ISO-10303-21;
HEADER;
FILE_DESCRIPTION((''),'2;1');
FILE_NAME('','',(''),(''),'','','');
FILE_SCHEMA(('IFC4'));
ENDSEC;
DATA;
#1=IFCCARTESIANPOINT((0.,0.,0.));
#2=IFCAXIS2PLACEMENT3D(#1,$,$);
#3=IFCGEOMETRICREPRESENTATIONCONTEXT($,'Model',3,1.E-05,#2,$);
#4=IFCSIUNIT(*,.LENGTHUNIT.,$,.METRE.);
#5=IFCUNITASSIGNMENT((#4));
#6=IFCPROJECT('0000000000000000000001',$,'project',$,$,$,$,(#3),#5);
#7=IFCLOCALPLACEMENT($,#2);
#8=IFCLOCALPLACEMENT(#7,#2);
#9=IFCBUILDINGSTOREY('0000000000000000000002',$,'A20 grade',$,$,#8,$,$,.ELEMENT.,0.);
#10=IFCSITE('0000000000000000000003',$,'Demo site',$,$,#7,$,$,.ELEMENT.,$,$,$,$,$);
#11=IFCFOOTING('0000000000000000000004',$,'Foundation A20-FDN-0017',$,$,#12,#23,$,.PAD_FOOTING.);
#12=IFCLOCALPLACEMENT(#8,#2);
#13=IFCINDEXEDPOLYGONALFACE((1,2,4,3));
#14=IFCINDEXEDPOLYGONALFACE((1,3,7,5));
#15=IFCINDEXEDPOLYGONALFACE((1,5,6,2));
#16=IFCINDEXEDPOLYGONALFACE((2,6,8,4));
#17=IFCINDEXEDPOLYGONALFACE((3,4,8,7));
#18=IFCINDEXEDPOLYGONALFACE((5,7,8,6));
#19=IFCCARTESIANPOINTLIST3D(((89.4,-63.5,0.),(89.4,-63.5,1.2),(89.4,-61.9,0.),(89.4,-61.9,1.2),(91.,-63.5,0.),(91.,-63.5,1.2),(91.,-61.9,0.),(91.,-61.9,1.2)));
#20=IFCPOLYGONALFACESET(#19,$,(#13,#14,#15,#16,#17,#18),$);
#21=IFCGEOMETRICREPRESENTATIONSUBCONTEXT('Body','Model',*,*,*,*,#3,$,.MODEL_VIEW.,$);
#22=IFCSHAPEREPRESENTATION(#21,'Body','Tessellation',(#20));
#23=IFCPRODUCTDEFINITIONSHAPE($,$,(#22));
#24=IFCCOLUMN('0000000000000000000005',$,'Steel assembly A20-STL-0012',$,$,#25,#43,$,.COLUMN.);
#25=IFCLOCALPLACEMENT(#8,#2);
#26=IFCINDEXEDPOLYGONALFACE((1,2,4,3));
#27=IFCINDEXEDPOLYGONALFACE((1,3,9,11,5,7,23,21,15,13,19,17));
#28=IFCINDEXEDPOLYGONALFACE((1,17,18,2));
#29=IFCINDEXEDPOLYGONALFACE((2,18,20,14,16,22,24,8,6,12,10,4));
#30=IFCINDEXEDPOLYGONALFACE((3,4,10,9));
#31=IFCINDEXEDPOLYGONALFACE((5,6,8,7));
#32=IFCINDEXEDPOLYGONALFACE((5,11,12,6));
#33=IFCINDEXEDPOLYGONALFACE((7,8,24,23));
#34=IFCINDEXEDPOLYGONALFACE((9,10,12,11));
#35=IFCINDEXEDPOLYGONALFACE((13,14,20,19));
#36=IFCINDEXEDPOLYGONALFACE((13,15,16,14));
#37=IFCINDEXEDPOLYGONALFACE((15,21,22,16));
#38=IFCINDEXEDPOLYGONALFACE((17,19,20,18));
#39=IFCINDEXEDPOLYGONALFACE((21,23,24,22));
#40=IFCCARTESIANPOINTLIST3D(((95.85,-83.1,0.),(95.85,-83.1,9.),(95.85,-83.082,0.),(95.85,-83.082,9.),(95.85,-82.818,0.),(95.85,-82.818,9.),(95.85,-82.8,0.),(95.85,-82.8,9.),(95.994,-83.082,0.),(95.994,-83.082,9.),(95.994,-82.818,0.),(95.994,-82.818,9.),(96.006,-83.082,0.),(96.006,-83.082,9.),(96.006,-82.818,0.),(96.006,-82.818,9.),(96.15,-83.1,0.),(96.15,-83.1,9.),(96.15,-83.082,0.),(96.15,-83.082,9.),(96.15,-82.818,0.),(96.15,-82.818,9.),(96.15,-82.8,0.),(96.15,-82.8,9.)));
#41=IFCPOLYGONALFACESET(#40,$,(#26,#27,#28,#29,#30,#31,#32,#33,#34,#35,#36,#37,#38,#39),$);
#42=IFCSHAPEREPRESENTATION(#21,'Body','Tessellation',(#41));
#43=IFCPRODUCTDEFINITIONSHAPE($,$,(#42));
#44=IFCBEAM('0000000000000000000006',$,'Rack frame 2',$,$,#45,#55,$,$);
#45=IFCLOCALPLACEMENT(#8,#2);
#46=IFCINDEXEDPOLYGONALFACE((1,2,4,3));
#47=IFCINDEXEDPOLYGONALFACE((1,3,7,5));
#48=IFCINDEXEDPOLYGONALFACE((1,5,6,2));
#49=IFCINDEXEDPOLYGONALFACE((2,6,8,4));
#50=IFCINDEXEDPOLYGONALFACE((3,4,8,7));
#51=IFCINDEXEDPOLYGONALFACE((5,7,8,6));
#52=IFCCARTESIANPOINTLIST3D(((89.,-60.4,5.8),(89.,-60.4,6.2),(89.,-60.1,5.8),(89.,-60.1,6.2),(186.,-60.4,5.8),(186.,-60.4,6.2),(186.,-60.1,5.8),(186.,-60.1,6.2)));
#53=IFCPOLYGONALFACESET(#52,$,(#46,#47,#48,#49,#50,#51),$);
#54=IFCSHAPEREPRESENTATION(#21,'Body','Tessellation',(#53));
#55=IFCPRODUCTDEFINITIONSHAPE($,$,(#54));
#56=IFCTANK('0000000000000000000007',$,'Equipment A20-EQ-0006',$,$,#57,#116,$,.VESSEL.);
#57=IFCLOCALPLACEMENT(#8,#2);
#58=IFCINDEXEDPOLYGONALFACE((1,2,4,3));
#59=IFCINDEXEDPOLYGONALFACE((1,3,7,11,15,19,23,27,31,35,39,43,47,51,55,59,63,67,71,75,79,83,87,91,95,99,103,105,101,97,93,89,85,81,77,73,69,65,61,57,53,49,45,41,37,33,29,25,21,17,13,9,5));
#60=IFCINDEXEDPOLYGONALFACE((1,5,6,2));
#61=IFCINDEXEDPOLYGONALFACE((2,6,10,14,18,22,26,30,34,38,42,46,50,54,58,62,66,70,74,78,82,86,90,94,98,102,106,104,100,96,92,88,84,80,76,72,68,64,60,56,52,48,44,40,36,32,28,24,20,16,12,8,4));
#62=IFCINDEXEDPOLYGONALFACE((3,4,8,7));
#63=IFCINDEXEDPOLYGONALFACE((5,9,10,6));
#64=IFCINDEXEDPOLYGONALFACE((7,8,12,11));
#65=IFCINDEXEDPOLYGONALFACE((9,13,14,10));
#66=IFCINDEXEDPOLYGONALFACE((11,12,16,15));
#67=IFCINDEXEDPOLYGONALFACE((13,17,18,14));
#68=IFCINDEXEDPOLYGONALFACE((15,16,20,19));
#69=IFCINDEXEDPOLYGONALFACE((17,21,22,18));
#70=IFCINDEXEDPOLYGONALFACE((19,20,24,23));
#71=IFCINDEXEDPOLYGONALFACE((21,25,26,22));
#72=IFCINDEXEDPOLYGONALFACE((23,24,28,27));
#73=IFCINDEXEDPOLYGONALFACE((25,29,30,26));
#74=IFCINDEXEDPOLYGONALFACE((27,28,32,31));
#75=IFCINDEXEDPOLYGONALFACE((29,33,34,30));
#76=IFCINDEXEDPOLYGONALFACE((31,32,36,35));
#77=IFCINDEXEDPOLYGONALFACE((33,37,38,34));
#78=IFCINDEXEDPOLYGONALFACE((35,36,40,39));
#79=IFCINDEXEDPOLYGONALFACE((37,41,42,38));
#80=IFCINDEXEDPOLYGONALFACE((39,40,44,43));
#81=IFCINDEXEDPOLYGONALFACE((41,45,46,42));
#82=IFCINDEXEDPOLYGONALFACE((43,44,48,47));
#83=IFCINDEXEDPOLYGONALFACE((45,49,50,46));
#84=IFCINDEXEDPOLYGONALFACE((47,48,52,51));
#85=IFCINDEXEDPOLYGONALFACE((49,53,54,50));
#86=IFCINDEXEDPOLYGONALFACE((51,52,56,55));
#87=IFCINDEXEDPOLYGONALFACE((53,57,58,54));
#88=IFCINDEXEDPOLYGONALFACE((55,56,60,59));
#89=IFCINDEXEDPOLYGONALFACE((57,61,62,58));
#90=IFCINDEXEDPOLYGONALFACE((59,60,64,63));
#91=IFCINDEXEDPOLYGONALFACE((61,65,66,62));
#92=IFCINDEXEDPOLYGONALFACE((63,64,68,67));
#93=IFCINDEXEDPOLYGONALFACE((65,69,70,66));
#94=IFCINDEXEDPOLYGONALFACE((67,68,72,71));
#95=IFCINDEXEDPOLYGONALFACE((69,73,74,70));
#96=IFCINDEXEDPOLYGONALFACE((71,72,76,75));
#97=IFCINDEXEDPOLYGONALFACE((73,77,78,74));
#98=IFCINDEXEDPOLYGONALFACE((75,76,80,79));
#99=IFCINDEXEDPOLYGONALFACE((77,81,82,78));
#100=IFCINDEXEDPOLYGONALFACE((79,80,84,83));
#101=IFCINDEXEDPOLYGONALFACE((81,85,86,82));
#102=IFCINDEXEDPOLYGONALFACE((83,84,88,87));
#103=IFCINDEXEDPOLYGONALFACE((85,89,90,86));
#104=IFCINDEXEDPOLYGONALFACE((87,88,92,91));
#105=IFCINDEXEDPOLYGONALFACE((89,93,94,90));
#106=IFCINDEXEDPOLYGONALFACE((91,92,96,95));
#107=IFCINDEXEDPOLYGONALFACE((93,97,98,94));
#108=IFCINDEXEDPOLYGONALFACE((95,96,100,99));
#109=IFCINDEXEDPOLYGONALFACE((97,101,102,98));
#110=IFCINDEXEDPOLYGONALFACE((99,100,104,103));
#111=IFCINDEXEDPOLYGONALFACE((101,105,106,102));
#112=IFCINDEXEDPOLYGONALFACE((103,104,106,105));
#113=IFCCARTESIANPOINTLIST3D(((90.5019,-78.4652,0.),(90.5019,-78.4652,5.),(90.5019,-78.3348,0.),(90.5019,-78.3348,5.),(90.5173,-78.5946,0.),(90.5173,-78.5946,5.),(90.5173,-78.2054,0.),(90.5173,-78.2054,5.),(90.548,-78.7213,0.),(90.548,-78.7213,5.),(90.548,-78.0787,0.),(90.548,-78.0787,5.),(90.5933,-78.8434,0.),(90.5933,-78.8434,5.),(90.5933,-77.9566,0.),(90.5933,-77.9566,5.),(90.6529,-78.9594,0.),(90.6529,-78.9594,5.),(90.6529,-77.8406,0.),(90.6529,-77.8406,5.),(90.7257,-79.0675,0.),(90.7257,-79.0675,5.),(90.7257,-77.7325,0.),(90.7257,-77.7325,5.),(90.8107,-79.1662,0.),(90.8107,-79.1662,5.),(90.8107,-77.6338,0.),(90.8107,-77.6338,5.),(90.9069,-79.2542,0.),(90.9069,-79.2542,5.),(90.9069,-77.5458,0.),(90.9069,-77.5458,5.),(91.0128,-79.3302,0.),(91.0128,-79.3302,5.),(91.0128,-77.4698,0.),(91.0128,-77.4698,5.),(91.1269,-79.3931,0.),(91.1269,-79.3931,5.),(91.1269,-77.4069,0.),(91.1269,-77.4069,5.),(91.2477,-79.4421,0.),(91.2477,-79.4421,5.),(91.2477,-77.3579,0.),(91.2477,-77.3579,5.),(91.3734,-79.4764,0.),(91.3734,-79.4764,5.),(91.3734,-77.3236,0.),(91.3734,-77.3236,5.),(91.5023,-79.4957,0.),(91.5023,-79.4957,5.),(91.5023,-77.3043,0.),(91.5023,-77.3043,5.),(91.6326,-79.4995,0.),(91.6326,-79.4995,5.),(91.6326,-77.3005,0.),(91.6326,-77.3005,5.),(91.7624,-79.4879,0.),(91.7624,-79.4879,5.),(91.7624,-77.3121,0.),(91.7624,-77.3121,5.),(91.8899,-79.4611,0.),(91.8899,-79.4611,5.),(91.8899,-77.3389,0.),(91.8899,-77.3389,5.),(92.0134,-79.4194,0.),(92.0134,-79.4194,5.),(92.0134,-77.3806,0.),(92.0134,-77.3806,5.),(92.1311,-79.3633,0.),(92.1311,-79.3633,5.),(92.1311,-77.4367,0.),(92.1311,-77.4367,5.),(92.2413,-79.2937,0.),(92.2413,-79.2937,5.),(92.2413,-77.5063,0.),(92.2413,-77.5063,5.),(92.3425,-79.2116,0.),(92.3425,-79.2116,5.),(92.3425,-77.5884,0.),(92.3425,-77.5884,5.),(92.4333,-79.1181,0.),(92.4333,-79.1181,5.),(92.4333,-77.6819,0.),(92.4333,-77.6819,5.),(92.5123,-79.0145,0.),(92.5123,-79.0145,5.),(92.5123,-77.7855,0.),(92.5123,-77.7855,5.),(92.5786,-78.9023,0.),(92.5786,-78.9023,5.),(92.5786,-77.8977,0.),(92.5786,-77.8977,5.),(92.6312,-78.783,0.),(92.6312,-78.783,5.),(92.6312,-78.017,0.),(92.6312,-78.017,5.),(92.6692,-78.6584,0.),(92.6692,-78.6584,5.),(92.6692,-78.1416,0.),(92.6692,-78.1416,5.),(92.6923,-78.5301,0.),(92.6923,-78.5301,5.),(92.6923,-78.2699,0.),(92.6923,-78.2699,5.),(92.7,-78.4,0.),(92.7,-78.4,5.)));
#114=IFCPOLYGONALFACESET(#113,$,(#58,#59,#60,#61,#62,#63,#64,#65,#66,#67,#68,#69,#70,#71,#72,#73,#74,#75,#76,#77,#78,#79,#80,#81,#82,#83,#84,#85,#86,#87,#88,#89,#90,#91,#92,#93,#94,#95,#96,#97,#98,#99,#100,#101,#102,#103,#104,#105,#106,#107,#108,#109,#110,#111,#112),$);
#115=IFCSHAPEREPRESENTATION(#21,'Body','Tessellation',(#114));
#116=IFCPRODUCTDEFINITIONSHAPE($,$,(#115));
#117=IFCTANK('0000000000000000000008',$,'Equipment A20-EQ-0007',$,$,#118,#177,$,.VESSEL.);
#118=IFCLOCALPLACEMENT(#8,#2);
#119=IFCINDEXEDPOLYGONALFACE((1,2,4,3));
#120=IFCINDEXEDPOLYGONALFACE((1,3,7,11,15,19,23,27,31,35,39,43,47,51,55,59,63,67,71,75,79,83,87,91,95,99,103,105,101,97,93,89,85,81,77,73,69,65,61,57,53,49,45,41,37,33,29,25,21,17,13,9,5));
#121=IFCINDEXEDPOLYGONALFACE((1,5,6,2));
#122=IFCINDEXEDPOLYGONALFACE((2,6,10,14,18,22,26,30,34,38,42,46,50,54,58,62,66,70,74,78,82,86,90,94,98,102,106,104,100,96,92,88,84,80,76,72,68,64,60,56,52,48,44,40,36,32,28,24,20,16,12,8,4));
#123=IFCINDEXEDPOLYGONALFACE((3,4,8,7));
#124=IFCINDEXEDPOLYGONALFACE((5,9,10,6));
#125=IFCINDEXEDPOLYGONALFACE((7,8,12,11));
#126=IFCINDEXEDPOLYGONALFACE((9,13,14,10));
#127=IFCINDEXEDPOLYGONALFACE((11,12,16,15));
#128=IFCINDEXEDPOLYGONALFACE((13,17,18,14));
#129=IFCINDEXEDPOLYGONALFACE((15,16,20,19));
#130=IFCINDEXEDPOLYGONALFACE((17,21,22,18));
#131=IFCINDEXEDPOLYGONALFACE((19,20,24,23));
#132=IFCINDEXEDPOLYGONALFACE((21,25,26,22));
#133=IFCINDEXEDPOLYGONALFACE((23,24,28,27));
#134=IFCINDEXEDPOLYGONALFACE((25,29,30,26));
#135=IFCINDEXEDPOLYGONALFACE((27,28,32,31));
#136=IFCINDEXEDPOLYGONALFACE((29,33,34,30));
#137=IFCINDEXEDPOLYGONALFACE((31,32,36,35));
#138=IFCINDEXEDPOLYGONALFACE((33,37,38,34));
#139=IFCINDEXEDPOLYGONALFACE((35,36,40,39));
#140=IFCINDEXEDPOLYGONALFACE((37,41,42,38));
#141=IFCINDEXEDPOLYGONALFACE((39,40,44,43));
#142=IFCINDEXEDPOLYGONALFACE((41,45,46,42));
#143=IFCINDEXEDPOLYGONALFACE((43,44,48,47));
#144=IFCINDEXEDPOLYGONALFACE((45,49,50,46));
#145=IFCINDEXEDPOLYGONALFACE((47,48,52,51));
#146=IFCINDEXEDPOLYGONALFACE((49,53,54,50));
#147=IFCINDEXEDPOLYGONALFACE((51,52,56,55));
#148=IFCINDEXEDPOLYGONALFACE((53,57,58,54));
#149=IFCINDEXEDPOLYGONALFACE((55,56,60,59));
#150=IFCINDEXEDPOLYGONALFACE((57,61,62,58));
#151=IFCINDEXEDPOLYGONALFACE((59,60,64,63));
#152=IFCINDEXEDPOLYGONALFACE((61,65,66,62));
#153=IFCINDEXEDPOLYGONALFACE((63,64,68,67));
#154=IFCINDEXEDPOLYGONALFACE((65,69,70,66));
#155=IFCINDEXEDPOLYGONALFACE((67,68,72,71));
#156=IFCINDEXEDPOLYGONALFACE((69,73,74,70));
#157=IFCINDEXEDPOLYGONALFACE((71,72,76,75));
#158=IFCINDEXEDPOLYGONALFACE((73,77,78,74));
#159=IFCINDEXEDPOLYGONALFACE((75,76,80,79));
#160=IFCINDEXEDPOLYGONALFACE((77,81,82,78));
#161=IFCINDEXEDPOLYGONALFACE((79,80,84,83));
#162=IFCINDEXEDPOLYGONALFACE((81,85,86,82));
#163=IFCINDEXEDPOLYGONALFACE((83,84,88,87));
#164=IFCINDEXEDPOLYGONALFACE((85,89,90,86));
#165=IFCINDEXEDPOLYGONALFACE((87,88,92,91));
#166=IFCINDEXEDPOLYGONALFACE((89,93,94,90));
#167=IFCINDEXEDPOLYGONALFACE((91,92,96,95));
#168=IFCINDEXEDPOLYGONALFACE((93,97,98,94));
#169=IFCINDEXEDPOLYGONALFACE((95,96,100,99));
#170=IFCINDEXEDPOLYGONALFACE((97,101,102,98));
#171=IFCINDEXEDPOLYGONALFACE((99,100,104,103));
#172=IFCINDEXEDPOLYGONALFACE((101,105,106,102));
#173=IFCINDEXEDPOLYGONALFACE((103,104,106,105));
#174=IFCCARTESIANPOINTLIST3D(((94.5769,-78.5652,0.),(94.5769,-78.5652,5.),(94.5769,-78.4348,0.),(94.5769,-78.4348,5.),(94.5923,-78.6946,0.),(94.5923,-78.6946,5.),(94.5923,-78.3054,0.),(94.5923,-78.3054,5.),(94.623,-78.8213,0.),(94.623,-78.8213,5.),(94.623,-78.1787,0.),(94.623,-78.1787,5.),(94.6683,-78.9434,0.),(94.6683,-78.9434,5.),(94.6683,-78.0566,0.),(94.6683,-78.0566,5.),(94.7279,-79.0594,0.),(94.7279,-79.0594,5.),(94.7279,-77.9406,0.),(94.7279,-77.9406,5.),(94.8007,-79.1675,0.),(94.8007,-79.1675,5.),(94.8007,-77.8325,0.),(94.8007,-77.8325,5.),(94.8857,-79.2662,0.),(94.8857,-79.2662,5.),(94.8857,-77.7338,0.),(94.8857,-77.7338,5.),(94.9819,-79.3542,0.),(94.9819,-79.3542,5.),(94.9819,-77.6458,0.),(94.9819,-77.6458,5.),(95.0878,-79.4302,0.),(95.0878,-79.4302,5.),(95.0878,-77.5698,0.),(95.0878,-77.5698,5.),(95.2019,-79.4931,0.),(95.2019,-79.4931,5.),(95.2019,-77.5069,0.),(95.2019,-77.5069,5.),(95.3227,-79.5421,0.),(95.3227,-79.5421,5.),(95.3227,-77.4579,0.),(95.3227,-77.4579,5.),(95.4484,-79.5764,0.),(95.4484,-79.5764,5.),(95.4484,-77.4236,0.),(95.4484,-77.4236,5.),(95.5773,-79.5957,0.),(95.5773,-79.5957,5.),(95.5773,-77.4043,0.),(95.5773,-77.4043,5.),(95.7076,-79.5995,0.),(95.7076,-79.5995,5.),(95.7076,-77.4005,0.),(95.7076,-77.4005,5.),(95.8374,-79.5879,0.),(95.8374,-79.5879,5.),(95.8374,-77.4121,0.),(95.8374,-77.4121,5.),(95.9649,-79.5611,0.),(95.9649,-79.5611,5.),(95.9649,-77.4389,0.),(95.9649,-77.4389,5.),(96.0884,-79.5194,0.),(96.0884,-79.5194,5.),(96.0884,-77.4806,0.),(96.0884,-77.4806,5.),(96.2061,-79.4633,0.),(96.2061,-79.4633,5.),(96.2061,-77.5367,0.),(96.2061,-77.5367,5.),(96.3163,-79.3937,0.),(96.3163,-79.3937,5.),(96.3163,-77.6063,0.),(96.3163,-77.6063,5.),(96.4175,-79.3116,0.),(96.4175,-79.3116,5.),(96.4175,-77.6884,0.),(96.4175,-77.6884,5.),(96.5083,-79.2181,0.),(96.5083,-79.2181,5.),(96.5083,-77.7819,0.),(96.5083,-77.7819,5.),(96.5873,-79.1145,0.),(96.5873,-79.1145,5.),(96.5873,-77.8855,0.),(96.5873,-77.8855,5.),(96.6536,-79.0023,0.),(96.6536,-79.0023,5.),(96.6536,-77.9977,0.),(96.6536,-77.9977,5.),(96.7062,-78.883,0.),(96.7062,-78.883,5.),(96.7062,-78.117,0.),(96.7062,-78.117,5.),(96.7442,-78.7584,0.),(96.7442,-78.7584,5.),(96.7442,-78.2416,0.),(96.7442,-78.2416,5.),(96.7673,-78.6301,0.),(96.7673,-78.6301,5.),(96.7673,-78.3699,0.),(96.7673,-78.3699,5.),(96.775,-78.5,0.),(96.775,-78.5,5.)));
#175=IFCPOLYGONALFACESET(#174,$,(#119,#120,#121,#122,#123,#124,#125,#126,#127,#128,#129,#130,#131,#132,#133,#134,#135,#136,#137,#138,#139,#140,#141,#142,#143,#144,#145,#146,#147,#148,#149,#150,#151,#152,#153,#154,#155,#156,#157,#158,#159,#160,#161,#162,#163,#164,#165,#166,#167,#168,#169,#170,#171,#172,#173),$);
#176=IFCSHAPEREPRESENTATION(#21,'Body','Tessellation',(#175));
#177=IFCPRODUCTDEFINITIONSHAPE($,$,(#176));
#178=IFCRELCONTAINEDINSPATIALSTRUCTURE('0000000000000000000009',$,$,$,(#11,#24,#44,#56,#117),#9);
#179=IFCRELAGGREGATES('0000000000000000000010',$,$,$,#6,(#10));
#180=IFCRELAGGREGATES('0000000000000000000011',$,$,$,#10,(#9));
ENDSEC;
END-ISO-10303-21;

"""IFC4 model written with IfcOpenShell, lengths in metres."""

from ifc_helpers import new_model, si_unit, frame, origin, place, context, subcontext, project, spatial, rectangle, circle, i_section, extrude, element, save


model = new_model("IFC4")

# Units and contexts
model_context = context("Model", 3, precision=1e-05, world=origin())
body_context = subcontext(model_context, "Body", "Model", "MODEL_VIEW")
ifc_project = project(units=[si_unit("LENGTHUNIT", "METRE")], contexts=[model_context])

# Site, storey
site_placement = place(None, origin())
site = spatial("IfcSite", under=ifc_project, at=site_placement, Name="Demo site", CompositionType="ELEMENT")
storey_placement = place(site_placement, origin())
storey = spatial("IfcBuildingStorey", under=site, at=storey_placement, Name="A20 grade", CompositionType="ELEMENT", Elevation=0.0)

# Footing
footing_placement = place(storey_placement, frame((90.2, -62.7, 0.0)))
element("IfcFooting", 1, at=footing_placement, inside=storey, Name="Foundation A20-FDN-0017", PredefinedType="PAD_FOOTING", context=body_context, shape_type="SweptSolid", body=[
    extrude(rectangle(XDim=1.6, YDim=1.6), origin(), (0.0, 0.0, 1.0), 1.2),
])

# Column
column_placement = place(storey_placement, frame((96.0, -82.95, 0.0)))
element("IfcColumn", 2, at=column_placement, inside=storey, Name="Steel assembly A20-STL-0012", PredefinedType="COLUMN", context=body_context, shape_type="SweptSolid", body=[
    extrude(i_section(OverallWidth=0.3, OverallDepth=0.3, WebThickness=0.012, FlangeThickness=0.018), origin(), (0.0, 0.0, 1.0), 9.0),
])

# Beam
beam_placement = place(storey_placement, frame((89.0, -60.25, 6.0)))
element("IfcBeam", 3, at=beam_placement, inside=storey, Name="Rack frame 2", context=body_context, shape_type="SweptSolid", body=[
    extrude(rectangle(XDim=0.3, YDim=0.4), frame((0.0, 0.0, 0.0), z_axis=(1.0, 0.0, 0.0), x_axis=(0.0, 1.0, 0.0)), (0.0, 0.0, 1.0), 97.0),
])

# Tanks
for number, where, name in (
    (4, (91.6, -78.4, 0.0), "Equipment A20-EQ-0006"),
    (5, (95.675, -78.5, 0.0), "Equipment A20-EQ-0007"),
):
    element("IfcTank", number, at=place(storey_placement, frame(where)), inside=storey, Name=name, PredefinedType="VESSEL", context=body_context, shape_type="SweptSolid", body=[
        extrude(circle(Radius=1.1), origin(), (0.0, 0.0, 1.0), 5.0),
    ])

save(model, "model.ifc")
